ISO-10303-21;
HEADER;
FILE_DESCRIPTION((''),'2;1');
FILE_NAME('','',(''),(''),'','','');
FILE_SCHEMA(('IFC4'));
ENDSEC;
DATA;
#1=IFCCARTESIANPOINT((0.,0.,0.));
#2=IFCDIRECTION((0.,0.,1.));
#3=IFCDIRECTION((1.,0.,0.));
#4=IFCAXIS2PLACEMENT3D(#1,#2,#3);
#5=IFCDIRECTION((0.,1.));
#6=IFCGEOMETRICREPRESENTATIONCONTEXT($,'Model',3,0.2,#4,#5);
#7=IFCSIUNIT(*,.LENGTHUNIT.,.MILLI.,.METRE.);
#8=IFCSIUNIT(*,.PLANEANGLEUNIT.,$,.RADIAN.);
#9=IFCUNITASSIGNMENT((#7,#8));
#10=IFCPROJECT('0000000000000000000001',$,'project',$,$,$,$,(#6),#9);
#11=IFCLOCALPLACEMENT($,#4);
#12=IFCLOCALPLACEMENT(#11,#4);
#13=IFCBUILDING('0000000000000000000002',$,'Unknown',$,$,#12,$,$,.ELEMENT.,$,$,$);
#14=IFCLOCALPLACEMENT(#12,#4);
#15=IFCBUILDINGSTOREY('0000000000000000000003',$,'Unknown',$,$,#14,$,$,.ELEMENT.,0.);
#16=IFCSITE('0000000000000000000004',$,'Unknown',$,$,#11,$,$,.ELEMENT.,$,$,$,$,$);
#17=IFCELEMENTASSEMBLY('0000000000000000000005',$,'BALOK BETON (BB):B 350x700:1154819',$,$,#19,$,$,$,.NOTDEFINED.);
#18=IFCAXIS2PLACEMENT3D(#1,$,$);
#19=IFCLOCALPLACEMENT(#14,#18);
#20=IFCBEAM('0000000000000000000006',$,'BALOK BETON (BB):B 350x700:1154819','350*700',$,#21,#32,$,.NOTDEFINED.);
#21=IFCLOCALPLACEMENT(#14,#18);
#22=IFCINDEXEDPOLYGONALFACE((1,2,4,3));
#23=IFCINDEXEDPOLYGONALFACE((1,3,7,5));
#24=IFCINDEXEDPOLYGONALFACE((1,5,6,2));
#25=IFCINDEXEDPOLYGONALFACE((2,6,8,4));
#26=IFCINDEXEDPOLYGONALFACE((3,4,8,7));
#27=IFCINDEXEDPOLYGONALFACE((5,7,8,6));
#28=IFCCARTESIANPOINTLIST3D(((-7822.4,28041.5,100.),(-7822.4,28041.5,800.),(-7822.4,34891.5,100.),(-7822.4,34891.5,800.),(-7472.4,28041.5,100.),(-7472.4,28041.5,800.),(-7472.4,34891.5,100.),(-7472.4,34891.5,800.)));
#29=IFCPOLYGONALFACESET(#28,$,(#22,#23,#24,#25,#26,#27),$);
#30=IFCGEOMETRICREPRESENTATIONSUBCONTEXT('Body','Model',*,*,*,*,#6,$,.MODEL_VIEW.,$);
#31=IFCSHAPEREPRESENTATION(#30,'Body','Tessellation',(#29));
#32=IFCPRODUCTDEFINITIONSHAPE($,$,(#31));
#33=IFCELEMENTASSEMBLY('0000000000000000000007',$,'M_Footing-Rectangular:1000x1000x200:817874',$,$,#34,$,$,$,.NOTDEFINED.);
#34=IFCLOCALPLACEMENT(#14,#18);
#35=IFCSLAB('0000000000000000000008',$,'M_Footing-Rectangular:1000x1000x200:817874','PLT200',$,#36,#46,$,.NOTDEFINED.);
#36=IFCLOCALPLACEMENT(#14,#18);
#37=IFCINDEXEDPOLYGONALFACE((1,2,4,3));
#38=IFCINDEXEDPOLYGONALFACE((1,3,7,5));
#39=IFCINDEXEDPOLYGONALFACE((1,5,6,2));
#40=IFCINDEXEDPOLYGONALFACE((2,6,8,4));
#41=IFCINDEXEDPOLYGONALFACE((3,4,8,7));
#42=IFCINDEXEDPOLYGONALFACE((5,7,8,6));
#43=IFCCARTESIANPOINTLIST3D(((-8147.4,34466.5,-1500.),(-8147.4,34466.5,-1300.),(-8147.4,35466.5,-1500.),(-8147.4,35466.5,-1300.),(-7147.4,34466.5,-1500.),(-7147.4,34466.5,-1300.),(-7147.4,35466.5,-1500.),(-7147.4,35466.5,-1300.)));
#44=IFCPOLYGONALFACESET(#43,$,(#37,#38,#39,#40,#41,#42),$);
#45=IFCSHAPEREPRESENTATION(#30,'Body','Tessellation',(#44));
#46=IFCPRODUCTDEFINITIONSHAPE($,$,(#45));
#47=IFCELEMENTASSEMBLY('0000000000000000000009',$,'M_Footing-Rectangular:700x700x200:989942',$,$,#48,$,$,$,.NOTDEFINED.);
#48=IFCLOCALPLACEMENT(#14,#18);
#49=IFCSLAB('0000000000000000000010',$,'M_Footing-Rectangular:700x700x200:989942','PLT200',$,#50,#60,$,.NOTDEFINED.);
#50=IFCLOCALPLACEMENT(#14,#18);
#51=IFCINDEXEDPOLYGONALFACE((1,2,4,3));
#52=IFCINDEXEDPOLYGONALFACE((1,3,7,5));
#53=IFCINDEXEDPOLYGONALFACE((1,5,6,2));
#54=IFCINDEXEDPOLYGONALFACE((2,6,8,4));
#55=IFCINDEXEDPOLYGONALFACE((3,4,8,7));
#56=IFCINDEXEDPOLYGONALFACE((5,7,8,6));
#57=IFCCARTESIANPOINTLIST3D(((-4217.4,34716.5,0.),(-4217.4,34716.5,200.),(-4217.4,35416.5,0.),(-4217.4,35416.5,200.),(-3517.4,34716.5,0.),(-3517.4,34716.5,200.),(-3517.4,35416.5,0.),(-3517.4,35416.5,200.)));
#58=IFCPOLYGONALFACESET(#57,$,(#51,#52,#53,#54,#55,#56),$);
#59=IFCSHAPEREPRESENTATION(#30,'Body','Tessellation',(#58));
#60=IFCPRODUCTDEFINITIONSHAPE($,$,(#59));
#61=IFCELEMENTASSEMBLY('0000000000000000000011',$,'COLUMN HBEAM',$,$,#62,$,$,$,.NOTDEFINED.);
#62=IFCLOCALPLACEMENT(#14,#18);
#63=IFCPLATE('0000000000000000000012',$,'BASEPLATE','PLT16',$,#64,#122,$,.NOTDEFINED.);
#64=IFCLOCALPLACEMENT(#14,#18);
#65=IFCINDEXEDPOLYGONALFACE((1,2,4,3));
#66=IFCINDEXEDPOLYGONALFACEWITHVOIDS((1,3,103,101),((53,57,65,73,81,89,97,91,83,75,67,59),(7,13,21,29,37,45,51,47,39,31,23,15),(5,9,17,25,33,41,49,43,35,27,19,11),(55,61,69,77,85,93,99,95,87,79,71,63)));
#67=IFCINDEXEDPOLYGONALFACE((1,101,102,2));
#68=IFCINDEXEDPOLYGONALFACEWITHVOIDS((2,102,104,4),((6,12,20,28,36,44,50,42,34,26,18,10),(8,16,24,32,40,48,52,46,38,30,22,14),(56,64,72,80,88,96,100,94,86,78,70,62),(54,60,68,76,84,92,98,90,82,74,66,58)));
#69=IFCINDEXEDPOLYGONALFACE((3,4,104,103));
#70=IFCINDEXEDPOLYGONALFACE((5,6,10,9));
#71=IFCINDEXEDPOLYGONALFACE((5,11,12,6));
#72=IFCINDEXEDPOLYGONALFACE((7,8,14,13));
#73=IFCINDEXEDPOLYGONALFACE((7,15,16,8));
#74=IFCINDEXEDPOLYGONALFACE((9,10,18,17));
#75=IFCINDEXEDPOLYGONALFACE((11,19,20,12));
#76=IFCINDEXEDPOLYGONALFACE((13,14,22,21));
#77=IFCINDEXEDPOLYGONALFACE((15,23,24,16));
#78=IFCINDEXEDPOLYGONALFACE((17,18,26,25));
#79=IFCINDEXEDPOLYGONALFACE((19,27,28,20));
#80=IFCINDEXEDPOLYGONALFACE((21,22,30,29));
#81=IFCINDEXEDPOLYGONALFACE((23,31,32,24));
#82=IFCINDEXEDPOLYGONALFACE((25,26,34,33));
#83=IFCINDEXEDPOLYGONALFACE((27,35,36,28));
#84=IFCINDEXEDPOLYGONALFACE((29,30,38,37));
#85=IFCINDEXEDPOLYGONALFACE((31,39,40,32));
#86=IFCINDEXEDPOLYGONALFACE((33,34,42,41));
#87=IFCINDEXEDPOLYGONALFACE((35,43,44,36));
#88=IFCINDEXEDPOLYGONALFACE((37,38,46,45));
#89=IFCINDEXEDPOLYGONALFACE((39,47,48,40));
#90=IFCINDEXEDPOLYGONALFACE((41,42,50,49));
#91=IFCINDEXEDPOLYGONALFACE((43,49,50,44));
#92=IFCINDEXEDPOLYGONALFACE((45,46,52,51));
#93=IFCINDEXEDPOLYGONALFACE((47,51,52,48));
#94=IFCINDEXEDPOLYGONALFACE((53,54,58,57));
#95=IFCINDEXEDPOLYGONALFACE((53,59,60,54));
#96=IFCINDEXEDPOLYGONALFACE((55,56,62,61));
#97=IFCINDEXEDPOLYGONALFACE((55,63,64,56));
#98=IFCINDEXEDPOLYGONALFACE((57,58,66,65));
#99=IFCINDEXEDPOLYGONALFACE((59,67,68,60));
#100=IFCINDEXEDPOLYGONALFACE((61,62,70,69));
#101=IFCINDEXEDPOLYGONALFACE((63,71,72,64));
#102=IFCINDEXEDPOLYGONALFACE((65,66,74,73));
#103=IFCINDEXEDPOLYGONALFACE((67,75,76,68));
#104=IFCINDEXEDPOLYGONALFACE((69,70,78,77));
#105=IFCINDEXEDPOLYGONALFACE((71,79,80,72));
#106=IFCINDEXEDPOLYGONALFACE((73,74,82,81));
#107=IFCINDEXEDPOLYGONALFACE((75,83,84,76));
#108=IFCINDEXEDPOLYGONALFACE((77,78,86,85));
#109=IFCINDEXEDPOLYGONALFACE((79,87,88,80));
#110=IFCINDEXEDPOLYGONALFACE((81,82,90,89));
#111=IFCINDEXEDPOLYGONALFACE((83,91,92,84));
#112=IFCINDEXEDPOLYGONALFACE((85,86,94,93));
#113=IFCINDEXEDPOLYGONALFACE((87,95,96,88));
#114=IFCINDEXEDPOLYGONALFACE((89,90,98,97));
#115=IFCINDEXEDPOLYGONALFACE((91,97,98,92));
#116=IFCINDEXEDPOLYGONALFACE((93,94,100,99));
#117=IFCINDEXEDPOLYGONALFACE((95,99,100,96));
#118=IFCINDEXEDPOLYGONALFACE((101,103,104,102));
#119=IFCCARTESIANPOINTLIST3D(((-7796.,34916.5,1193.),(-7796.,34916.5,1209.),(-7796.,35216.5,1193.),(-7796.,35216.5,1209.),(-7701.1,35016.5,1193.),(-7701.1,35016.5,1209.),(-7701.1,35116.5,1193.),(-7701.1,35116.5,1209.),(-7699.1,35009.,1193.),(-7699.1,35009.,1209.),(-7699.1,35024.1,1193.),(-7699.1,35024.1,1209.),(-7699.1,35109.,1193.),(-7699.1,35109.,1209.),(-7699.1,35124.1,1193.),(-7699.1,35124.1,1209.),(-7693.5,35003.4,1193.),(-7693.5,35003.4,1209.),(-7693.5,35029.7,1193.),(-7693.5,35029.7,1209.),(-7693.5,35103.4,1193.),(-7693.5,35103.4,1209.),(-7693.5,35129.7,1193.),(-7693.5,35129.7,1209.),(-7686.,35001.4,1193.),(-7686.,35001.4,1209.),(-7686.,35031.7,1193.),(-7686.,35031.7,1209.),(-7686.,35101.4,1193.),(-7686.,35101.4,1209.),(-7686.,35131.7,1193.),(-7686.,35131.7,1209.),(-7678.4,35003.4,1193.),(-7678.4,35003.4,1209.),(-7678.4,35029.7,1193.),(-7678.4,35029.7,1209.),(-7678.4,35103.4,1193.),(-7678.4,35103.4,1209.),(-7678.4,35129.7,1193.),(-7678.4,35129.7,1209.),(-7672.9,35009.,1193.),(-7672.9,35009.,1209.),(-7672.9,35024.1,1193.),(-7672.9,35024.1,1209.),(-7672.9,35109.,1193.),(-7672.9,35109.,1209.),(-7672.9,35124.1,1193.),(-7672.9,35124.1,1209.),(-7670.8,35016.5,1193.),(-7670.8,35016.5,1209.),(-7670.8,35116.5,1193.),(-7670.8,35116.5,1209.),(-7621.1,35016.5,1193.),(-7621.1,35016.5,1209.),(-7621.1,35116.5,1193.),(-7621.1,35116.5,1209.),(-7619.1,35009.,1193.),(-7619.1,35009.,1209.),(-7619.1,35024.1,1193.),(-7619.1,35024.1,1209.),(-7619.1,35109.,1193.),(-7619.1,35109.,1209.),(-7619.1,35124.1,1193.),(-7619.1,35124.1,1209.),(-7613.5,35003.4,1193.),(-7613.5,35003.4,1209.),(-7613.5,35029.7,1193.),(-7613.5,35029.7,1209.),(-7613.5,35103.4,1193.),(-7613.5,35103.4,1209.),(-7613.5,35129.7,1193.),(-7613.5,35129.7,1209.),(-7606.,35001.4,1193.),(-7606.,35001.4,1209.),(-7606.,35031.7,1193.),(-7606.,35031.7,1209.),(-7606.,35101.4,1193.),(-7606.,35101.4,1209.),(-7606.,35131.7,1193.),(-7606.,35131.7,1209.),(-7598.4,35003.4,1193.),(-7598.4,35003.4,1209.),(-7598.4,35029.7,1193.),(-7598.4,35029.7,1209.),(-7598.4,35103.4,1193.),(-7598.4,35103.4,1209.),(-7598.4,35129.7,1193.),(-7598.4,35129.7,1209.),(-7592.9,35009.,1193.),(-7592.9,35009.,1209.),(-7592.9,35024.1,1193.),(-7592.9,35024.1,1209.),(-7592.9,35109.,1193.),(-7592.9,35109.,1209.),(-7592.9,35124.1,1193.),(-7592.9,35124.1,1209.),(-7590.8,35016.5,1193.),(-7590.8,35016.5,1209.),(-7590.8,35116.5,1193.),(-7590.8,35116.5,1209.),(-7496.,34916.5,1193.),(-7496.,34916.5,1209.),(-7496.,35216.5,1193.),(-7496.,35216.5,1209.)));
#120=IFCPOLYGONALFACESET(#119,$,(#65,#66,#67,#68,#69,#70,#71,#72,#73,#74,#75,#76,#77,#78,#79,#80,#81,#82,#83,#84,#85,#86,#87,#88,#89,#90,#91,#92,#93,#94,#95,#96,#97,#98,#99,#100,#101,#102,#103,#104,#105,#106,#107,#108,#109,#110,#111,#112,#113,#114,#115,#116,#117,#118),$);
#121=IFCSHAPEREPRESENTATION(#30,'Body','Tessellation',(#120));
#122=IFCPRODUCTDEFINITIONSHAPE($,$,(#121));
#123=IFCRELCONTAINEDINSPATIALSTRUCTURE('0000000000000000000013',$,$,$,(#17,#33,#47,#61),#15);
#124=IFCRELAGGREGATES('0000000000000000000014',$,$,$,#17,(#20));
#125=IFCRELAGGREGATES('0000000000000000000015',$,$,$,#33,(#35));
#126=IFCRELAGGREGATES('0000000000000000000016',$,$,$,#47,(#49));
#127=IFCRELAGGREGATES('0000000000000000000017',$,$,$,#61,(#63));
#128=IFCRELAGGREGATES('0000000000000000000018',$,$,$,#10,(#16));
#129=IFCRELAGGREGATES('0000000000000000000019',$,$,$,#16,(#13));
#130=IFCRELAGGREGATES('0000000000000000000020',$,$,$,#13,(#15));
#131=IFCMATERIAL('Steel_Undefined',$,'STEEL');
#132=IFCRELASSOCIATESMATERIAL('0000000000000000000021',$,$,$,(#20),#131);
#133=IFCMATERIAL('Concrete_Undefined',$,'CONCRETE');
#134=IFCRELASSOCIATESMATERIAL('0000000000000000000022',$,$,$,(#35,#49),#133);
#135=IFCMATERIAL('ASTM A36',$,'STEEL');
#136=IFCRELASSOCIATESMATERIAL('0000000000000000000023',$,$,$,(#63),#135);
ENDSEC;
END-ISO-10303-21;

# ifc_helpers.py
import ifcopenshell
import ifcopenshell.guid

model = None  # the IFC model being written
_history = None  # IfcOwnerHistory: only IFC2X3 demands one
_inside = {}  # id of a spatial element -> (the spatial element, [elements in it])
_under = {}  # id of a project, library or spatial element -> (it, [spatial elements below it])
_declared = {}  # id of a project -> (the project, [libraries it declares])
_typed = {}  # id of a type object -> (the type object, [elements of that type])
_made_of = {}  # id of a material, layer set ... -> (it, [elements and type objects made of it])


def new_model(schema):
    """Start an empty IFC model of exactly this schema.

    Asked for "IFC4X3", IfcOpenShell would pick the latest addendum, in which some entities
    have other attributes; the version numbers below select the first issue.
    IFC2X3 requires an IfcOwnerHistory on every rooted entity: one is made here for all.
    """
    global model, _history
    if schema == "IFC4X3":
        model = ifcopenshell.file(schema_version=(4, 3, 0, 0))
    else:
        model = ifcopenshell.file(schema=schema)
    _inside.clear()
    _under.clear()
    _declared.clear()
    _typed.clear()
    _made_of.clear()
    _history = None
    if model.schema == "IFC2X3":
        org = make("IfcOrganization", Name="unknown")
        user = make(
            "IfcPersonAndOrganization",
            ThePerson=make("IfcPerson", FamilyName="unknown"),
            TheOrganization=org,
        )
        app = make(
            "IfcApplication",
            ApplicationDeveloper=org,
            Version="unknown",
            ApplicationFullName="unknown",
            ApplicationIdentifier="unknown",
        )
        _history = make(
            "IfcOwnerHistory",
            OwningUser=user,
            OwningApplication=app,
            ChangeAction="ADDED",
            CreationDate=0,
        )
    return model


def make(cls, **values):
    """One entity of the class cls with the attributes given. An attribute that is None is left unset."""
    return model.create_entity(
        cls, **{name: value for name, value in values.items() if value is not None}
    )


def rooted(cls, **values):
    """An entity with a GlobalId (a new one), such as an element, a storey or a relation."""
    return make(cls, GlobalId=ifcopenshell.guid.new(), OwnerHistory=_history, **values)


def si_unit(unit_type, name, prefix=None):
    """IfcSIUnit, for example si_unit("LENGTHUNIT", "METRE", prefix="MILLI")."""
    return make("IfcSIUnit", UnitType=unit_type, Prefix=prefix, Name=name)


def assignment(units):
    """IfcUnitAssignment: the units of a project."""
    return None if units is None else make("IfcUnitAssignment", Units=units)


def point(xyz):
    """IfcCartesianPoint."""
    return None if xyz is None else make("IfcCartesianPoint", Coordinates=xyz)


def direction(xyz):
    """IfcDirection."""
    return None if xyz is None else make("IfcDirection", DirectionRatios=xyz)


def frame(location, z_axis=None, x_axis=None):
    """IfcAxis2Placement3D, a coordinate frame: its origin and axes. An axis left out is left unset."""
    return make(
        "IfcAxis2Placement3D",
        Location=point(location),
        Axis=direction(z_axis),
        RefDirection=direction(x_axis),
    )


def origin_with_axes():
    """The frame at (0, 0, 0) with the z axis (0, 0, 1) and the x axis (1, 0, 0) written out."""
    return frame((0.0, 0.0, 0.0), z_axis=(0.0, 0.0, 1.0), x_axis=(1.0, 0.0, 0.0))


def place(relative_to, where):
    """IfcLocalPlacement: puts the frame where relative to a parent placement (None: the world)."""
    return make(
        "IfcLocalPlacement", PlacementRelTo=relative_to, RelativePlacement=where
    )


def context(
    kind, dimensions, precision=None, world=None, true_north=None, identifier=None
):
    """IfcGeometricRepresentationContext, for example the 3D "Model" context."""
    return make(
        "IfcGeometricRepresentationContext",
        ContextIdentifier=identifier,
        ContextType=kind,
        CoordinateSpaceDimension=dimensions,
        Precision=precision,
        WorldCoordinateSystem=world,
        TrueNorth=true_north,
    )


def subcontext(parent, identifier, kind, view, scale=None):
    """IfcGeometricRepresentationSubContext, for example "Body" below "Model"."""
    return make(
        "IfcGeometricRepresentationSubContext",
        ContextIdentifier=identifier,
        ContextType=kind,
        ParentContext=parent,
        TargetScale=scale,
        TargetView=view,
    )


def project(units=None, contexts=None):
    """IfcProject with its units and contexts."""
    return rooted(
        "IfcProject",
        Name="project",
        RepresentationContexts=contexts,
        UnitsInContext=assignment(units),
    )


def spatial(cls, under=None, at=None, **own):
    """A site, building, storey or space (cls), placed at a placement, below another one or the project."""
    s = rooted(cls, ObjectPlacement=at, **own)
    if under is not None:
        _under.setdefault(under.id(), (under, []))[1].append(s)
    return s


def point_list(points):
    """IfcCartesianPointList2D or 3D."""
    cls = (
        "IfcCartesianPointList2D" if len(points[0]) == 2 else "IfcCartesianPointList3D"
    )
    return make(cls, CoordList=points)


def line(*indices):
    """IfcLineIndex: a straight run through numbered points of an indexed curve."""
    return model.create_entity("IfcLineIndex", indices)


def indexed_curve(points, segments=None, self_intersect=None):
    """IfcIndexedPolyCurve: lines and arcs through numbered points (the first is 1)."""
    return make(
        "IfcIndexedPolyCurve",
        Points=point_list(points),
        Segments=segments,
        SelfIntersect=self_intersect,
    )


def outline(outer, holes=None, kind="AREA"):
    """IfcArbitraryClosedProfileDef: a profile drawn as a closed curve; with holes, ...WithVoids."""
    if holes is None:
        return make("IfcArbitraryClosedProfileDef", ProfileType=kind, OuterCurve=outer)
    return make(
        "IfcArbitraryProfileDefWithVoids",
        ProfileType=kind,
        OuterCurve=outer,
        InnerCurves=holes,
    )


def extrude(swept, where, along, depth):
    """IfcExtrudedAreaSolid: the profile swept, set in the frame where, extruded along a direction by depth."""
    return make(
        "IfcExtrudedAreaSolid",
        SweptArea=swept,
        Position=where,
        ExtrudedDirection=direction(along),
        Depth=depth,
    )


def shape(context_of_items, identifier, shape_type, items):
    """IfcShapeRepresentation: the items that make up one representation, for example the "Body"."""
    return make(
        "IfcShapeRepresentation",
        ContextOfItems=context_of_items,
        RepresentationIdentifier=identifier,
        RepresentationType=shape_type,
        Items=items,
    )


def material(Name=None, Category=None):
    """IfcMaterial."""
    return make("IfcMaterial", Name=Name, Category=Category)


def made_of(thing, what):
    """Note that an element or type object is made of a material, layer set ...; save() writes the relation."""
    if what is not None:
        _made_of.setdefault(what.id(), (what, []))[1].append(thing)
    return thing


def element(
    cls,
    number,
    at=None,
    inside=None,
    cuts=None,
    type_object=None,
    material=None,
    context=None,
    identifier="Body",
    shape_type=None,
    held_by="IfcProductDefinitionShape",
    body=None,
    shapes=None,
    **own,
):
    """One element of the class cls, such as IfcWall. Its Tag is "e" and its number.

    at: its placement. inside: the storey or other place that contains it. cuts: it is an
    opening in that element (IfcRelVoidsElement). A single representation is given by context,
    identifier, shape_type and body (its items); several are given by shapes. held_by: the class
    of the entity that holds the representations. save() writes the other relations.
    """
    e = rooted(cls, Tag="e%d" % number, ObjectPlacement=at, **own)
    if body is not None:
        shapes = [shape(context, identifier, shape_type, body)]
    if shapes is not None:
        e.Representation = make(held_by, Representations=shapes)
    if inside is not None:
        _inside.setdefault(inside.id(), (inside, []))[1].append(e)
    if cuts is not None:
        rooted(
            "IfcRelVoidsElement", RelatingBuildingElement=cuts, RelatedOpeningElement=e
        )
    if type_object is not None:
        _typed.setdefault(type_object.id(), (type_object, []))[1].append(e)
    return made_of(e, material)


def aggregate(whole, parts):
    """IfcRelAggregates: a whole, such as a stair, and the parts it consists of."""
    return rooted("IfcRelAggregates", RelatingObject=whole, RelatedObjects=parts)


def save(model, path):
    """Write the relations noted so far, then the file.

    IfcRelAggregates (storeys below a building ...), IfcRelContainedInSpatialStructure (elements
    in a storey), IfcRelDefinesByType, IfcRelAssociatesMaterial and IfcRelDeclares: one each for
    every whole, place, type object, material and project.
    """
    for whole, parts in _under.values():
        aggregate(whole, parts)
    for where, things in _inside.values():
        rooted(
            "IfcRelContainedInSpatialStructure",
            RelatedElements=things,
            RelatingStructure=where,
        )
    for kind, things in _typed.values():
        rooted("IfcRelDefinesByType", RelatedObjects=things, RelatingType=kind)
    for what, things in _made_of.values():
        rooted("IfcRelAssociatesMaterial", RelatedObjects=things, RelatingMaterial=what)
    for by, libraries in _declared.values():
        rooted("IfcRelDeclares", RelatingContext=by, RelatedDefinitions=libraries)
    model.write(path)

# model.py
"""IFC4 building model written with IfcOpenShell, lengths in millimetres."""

from ifc_helpers import new_model, si_unit, direction, frame, origin_with_axes, place, context, subcontext, project, spatial, line, indexed_curve, outline, extrude, material, element, aggregate, save


model = new_model("IFC4")

# Units and contexts
model_context = context("Model", 3, precision=0.2, world=origin_with_axes(), true_north=direction((0.0, 1.0)))
body_context = subcontext(model_context, "Body", "Model", "MODEL_VIEW")
ifc_project = project(units=[si_unit("LENGTHUNIT", "METRE", prefix="MILLI"), si_unit("PLANEANGLEUNIT", "RADIAN")], contexts=[model_context])

# Site, building, storey
site_placement = place(None, origin_with_axes())
site = spatial("IfcSite", under=ifc_project, at=site_placement, Name="Unknown", CompositionType="ELEMENT")
building_placement = place(site_placement, origin_with_axes())
building = spatial("IfcBuilding", under=site, at=building_placement, Name="Unknown", CompositionType="ELEMENT")
storey_placement = place(building_placement, origin_with_axes())
storey = spatial("IfcBuildingStorey", under=building, at=storey_placement, Name="Unknown", CompositionType="ELEMENT", Elevation=0.0)

# Shared definitions
ifc_material_1 = material(Name="Steel_Undefined", Category="STEEL")

# Element assembly, beam
assembly_1_placement = place(storey_placement, frame((-7647.4, 34891.5, 450.0), z_axis=(0.0, 0.0, 1.0), x_axis=(0.0, -1.0, 0.0)))
assembly_1 = element("IfcElementAssembly", 1, at=assembly_1_placement, inside=storey, Name="BALOK BETON (BB):B 350x700:1154819", PredefinedType="NOTDEFINED")
beam_placement = place(assembly_1_placement, origin_with_axes())
beam = element("IfcBeam", 2, at=beam_placement, material=ifc_material_1, Name="BALOK BETON (BB):B 350x700:1154819", Description="350*700", PredefinedType="NOTDEFINED", context=body_context, shape_type="SolidModel", body=[
    extrude(outline(indexed_curve([(-350.0, -175.0), (350.0, -175.0), (350.0, 175.0), (-350.0, 175.0)], segments=[line(1, 2, 3, 4, 1)])), frame((0.0, 0.0, 0.0), z_axis=(-1.0, 0.0, 0.0), x_axis=(0.0, 0.0, 1.0)), (0.0, 0.0, -1.0), 6850.0),
])
aggregate(assembly_1, [beam])

# Element assemblies, slabs
assembly_2_placement = place(storey_placement, frame((-8147.4, 35466.5, -1400.0), z_axis=(0.0, 0.0, -1.0), x_axis=(1.0, 0.0, 0.0)))
assembly_2 = element("IfcElementAssembly", 3, at=assembly_2_placement, inside=storey, Name="M_Footing-Rectangular:1000x1000x200:817874", PredefinedType="NOTDEFINED")
ifc_material_2 = material(Name="Concrete_Undefined", Category="CONCRETE")
slab_1_placement = place(assembly_2_placement, origin_with_axes())
slab_1 = element("IfcSlab", 4, at=slab_1_placement, material=ifc_material_2, Name="M_Footing-Rectangular:1000x1000x200:817874", Description="PLT200", PredefinedType="NOTDEFINED", context=body_context, shape_type="SolidModel", body=[
    extrude(outline(indexed_curve([(0.0, 0.0), (1000.0, 0.0), (1000.0, 1000.0), (0.0, 1000.0)], segments=[line(1, 2, 3, 4, 1)])), frame((0.0, 0.0, 100.0), z_axis=(0.0, 0.0, 1.0), x_axis=(1.0, 0.0, 0.0)), (0.0, 0.0, -1.0), 200.0),
])
aggregate(assembly_2, [slab_1])
assembly_3_placement = place(storey_placement, frame((-4217.4, 35416.5, 100.0), z_axis=(0.0, 0.0, -1.0), x_axis=(1.0, 0.0, 0.0)))
assembly_3 = element("IfcElementAssembly", 5, at=assembly_3_placement, inside=storey, Name="M_Footing-Rectangular:700x700x200:989942", PredefinedType="NOTDEFINED")
slab_2_placement = place(assembly_3_placement, origin_with_axes())
slab_2 = element("IfcSlab", 6, at=slab_2_placement, material=ifc_material_2, Name="M_Footing-Rectangular:700x700x200:989942", Description="PLT200", PredefinedType="NOTDEFINED", context=body_context, shape_type="SolidModel", body=[
    extrude(outline(indexed_curve([(0.0, 0.0), (700.0, 0.0), (700.0, 700.0), (0.0, 700.0)], segments=[line(1, 2, 3, 4, 1)])), frame((0.0, 0.0, 100.0), z_axis=(0.0, 0.0, 1.0), x_axis=(1.0, 0.0, 0.0)), (0.0, 0.0, -1.0), 200.0),
])
aggregate(assembly_3, [slab_2])

# Element assembly, plate, voiding features
assembly_4_placement = place(storey_placement, frame((-7668.5, 35066.5, 952.0), z_axis=(0.0, -1.0, 0.0), x_axis=(0.087153, 0.0, 0.996195)))
assembly_4 = element("IfcElementAssembly", 7, at=assembly_4_placement, inside=storey, Name="COLUMN HBEAM", PredefinedType="NOTDEFINED")
ifc_material_3 = material(Name="ASTM A36", Category="STEEL")
plate_1_placement = place(assembly_4_placement, frame((237.0, 148.7, 150.0), z_axis=(-0.996195, -0.087153, 0.0), x_axis=(0.0, 0.0, -1.0)))
plate_1 = element("IfcPlate", 8, at=plate_1_placement, material=ifc_material_3, Name="BASEPLATE", Description="PLT16", PredefinedType="NOTDEFINED", context=body_context, shape_type="SolidModel", body=[
    extrude(outline(indexed_curve([(0.0, 0.0), (300.0, 0.0), (300.0, 300.0), (0.0, 300.0)], segments=[line(1, 2, 3, 4, 1)])), frame((0.0, 0.0, 8.0), z_axis=(0.0, 0.0, 1.0), x_axis=(1.0, 0.0, 0.0)), (0.0, 0.0, -1.0), 16.0),
])
voiding_feature_1_placement = place(plate_1_placement, frame((200.0, 110.0, 8.5), z_axis=(-1.0, 0.0, 0.0), x_axis=(0.0, 0.0, -1.0)))
element("IfcVoidingFeature", 9, at=voiding_feature_1_placement, cuts=plate_1, Name="BEAM", PredefinedType="HOLE", context=body_context, shape_type="SolidModel", body=[
    extrude(outline(indexed_curve([(15.1, 0.0), (13.1, 7.6), (7.6, 13.1), (0.0, 15.1), (-7.6, 13.1), (-13.1, 7.6), (-15.1, 0.0), (-13.1, -7.6), (-7.6, -13.1), (0.0, -15.1), (7.6, -13.1), (13.1, -7.6)], segments=[line(1, 2, 3, 4, 5, 6, 7, 8, 9, 10, 11, 12, 1)])), frame((0.0, 0.0, 0.0), z_axis=(-1.0, 0.0, 0.0), x_axis=(0.0, 0.0, 1.0)), (0.0, 0.0, -1.0), 17.0),
])
voiding_feature_2_placement = place(plate_1_placement, frame((100.0, 110.0, 8.5), z_axis=(-1.0, 0.0, 0.0), x_axis=(0.0, 0.0, -1.0)))
element("IfcVoidingFeature", 10, at=voiding_feature_2_placement, cuts=plate_1, Name="BEAM", PredefinedType="HOLE", context=body_context, shape_type="SolidModel", body=[
    extrude(outline(indexed_curve([(15.1, 0.0), (13.1, 7.6), (7.6, 13.1), (0.0, 15.1), (-7.6, 13.1), (-13.1, 7.6), (-15.1, 0.0), (-13.1, -7.6), (-7.6, -13.1), (0.0, -15.1), (7.6, -13.1), (13.1, -7.6)], segments=[line(1, 2, 3, 4, 5, 6, 7, 8, 9, 10, 11, 12, 1)])), frame((0.0, 0.0, 0.0), z_axis=(-1.0, 0.0, 0.0), x_axis=(0.0, 0.0, 1.0)), (0.0, 0.0, -1.0), 17.0),
])
voiding_feature_3_placement = place(plate_1_placement, frame((200.0, 190.0, 8.5), z_axis=(-1.0, 0.0, 0.0), x_axis=(0.0, 0.0, -1.0)))
element("IfcVoidingFeature", 11, at=voiding_feature_3_placement, cuts=plate_1, Name="BEAM", PredefinedType="HOLE", context=body_context, shape_type="SolidModel", body=[
    extrude(outline(indexed_curve([(15.1, 0.0), (13.1, 7.6), (7.6, 13.1), (0.0, 15.1), (-7.6, 13.1), (-13.1, 7.6), (-15.1, 0.0), (-13.1, -7.6), (-7.6, -13.1), (0.0, -15.1), (7.6, -13.1), (13.1, -7.6)], segments=[line(1, 2, 3, 4, 5, 6, 7, 8, 9, 10, 11, 12, 1)])), frame((0.0, 0.0, 0.0), z_axis=(-1.0, 0.0, 0.0), x_axis=(0.0, 0.0, 1.0)), (0.0, 0.0, -1.0), 17.0),
])
voiding_feature_4_placement = place(plate_1_placement, frame((100.0, 190.0, 8.5), z_axis=(-1.0, 0.0, 0.0), x_axis=(0.0, 0.0, -1.0)))
element("IfcVoidingFeature", 12, at=voiding_feature_4_placement, cuts=plate_1, Name="BEAM", PredefinedType="HOLE", context=body_context, shape_type="SolidModel", body=[
    extrude(outline(indexed_curve([(15.1, 0.0), (13.1, 7.6), (7.6, 13.1), (0.0, 15.1), (-7.6, 13.1), (-13.1, 7.6), (-15.1, 0.0), (-13.1, -7.6), (-7.6, -13.1), (0.0, -15.1), (7.6, -13.1), (13.1, -7.6)], segments=[line(1, 2, 3, 4, 5, 6, 7, 8, 9, 10, 11, 12, 1)])), frame((0.0, 0.0, 0.0), z_axis=(-1.0, 0.0, 0.0), x_axis=(0.0, 0.0, 1.0)), (0.0, 0.0, -1.0), 17.0),
])
aggregate(assembly_4, [plate_1])

save(model, "model.ifc")
